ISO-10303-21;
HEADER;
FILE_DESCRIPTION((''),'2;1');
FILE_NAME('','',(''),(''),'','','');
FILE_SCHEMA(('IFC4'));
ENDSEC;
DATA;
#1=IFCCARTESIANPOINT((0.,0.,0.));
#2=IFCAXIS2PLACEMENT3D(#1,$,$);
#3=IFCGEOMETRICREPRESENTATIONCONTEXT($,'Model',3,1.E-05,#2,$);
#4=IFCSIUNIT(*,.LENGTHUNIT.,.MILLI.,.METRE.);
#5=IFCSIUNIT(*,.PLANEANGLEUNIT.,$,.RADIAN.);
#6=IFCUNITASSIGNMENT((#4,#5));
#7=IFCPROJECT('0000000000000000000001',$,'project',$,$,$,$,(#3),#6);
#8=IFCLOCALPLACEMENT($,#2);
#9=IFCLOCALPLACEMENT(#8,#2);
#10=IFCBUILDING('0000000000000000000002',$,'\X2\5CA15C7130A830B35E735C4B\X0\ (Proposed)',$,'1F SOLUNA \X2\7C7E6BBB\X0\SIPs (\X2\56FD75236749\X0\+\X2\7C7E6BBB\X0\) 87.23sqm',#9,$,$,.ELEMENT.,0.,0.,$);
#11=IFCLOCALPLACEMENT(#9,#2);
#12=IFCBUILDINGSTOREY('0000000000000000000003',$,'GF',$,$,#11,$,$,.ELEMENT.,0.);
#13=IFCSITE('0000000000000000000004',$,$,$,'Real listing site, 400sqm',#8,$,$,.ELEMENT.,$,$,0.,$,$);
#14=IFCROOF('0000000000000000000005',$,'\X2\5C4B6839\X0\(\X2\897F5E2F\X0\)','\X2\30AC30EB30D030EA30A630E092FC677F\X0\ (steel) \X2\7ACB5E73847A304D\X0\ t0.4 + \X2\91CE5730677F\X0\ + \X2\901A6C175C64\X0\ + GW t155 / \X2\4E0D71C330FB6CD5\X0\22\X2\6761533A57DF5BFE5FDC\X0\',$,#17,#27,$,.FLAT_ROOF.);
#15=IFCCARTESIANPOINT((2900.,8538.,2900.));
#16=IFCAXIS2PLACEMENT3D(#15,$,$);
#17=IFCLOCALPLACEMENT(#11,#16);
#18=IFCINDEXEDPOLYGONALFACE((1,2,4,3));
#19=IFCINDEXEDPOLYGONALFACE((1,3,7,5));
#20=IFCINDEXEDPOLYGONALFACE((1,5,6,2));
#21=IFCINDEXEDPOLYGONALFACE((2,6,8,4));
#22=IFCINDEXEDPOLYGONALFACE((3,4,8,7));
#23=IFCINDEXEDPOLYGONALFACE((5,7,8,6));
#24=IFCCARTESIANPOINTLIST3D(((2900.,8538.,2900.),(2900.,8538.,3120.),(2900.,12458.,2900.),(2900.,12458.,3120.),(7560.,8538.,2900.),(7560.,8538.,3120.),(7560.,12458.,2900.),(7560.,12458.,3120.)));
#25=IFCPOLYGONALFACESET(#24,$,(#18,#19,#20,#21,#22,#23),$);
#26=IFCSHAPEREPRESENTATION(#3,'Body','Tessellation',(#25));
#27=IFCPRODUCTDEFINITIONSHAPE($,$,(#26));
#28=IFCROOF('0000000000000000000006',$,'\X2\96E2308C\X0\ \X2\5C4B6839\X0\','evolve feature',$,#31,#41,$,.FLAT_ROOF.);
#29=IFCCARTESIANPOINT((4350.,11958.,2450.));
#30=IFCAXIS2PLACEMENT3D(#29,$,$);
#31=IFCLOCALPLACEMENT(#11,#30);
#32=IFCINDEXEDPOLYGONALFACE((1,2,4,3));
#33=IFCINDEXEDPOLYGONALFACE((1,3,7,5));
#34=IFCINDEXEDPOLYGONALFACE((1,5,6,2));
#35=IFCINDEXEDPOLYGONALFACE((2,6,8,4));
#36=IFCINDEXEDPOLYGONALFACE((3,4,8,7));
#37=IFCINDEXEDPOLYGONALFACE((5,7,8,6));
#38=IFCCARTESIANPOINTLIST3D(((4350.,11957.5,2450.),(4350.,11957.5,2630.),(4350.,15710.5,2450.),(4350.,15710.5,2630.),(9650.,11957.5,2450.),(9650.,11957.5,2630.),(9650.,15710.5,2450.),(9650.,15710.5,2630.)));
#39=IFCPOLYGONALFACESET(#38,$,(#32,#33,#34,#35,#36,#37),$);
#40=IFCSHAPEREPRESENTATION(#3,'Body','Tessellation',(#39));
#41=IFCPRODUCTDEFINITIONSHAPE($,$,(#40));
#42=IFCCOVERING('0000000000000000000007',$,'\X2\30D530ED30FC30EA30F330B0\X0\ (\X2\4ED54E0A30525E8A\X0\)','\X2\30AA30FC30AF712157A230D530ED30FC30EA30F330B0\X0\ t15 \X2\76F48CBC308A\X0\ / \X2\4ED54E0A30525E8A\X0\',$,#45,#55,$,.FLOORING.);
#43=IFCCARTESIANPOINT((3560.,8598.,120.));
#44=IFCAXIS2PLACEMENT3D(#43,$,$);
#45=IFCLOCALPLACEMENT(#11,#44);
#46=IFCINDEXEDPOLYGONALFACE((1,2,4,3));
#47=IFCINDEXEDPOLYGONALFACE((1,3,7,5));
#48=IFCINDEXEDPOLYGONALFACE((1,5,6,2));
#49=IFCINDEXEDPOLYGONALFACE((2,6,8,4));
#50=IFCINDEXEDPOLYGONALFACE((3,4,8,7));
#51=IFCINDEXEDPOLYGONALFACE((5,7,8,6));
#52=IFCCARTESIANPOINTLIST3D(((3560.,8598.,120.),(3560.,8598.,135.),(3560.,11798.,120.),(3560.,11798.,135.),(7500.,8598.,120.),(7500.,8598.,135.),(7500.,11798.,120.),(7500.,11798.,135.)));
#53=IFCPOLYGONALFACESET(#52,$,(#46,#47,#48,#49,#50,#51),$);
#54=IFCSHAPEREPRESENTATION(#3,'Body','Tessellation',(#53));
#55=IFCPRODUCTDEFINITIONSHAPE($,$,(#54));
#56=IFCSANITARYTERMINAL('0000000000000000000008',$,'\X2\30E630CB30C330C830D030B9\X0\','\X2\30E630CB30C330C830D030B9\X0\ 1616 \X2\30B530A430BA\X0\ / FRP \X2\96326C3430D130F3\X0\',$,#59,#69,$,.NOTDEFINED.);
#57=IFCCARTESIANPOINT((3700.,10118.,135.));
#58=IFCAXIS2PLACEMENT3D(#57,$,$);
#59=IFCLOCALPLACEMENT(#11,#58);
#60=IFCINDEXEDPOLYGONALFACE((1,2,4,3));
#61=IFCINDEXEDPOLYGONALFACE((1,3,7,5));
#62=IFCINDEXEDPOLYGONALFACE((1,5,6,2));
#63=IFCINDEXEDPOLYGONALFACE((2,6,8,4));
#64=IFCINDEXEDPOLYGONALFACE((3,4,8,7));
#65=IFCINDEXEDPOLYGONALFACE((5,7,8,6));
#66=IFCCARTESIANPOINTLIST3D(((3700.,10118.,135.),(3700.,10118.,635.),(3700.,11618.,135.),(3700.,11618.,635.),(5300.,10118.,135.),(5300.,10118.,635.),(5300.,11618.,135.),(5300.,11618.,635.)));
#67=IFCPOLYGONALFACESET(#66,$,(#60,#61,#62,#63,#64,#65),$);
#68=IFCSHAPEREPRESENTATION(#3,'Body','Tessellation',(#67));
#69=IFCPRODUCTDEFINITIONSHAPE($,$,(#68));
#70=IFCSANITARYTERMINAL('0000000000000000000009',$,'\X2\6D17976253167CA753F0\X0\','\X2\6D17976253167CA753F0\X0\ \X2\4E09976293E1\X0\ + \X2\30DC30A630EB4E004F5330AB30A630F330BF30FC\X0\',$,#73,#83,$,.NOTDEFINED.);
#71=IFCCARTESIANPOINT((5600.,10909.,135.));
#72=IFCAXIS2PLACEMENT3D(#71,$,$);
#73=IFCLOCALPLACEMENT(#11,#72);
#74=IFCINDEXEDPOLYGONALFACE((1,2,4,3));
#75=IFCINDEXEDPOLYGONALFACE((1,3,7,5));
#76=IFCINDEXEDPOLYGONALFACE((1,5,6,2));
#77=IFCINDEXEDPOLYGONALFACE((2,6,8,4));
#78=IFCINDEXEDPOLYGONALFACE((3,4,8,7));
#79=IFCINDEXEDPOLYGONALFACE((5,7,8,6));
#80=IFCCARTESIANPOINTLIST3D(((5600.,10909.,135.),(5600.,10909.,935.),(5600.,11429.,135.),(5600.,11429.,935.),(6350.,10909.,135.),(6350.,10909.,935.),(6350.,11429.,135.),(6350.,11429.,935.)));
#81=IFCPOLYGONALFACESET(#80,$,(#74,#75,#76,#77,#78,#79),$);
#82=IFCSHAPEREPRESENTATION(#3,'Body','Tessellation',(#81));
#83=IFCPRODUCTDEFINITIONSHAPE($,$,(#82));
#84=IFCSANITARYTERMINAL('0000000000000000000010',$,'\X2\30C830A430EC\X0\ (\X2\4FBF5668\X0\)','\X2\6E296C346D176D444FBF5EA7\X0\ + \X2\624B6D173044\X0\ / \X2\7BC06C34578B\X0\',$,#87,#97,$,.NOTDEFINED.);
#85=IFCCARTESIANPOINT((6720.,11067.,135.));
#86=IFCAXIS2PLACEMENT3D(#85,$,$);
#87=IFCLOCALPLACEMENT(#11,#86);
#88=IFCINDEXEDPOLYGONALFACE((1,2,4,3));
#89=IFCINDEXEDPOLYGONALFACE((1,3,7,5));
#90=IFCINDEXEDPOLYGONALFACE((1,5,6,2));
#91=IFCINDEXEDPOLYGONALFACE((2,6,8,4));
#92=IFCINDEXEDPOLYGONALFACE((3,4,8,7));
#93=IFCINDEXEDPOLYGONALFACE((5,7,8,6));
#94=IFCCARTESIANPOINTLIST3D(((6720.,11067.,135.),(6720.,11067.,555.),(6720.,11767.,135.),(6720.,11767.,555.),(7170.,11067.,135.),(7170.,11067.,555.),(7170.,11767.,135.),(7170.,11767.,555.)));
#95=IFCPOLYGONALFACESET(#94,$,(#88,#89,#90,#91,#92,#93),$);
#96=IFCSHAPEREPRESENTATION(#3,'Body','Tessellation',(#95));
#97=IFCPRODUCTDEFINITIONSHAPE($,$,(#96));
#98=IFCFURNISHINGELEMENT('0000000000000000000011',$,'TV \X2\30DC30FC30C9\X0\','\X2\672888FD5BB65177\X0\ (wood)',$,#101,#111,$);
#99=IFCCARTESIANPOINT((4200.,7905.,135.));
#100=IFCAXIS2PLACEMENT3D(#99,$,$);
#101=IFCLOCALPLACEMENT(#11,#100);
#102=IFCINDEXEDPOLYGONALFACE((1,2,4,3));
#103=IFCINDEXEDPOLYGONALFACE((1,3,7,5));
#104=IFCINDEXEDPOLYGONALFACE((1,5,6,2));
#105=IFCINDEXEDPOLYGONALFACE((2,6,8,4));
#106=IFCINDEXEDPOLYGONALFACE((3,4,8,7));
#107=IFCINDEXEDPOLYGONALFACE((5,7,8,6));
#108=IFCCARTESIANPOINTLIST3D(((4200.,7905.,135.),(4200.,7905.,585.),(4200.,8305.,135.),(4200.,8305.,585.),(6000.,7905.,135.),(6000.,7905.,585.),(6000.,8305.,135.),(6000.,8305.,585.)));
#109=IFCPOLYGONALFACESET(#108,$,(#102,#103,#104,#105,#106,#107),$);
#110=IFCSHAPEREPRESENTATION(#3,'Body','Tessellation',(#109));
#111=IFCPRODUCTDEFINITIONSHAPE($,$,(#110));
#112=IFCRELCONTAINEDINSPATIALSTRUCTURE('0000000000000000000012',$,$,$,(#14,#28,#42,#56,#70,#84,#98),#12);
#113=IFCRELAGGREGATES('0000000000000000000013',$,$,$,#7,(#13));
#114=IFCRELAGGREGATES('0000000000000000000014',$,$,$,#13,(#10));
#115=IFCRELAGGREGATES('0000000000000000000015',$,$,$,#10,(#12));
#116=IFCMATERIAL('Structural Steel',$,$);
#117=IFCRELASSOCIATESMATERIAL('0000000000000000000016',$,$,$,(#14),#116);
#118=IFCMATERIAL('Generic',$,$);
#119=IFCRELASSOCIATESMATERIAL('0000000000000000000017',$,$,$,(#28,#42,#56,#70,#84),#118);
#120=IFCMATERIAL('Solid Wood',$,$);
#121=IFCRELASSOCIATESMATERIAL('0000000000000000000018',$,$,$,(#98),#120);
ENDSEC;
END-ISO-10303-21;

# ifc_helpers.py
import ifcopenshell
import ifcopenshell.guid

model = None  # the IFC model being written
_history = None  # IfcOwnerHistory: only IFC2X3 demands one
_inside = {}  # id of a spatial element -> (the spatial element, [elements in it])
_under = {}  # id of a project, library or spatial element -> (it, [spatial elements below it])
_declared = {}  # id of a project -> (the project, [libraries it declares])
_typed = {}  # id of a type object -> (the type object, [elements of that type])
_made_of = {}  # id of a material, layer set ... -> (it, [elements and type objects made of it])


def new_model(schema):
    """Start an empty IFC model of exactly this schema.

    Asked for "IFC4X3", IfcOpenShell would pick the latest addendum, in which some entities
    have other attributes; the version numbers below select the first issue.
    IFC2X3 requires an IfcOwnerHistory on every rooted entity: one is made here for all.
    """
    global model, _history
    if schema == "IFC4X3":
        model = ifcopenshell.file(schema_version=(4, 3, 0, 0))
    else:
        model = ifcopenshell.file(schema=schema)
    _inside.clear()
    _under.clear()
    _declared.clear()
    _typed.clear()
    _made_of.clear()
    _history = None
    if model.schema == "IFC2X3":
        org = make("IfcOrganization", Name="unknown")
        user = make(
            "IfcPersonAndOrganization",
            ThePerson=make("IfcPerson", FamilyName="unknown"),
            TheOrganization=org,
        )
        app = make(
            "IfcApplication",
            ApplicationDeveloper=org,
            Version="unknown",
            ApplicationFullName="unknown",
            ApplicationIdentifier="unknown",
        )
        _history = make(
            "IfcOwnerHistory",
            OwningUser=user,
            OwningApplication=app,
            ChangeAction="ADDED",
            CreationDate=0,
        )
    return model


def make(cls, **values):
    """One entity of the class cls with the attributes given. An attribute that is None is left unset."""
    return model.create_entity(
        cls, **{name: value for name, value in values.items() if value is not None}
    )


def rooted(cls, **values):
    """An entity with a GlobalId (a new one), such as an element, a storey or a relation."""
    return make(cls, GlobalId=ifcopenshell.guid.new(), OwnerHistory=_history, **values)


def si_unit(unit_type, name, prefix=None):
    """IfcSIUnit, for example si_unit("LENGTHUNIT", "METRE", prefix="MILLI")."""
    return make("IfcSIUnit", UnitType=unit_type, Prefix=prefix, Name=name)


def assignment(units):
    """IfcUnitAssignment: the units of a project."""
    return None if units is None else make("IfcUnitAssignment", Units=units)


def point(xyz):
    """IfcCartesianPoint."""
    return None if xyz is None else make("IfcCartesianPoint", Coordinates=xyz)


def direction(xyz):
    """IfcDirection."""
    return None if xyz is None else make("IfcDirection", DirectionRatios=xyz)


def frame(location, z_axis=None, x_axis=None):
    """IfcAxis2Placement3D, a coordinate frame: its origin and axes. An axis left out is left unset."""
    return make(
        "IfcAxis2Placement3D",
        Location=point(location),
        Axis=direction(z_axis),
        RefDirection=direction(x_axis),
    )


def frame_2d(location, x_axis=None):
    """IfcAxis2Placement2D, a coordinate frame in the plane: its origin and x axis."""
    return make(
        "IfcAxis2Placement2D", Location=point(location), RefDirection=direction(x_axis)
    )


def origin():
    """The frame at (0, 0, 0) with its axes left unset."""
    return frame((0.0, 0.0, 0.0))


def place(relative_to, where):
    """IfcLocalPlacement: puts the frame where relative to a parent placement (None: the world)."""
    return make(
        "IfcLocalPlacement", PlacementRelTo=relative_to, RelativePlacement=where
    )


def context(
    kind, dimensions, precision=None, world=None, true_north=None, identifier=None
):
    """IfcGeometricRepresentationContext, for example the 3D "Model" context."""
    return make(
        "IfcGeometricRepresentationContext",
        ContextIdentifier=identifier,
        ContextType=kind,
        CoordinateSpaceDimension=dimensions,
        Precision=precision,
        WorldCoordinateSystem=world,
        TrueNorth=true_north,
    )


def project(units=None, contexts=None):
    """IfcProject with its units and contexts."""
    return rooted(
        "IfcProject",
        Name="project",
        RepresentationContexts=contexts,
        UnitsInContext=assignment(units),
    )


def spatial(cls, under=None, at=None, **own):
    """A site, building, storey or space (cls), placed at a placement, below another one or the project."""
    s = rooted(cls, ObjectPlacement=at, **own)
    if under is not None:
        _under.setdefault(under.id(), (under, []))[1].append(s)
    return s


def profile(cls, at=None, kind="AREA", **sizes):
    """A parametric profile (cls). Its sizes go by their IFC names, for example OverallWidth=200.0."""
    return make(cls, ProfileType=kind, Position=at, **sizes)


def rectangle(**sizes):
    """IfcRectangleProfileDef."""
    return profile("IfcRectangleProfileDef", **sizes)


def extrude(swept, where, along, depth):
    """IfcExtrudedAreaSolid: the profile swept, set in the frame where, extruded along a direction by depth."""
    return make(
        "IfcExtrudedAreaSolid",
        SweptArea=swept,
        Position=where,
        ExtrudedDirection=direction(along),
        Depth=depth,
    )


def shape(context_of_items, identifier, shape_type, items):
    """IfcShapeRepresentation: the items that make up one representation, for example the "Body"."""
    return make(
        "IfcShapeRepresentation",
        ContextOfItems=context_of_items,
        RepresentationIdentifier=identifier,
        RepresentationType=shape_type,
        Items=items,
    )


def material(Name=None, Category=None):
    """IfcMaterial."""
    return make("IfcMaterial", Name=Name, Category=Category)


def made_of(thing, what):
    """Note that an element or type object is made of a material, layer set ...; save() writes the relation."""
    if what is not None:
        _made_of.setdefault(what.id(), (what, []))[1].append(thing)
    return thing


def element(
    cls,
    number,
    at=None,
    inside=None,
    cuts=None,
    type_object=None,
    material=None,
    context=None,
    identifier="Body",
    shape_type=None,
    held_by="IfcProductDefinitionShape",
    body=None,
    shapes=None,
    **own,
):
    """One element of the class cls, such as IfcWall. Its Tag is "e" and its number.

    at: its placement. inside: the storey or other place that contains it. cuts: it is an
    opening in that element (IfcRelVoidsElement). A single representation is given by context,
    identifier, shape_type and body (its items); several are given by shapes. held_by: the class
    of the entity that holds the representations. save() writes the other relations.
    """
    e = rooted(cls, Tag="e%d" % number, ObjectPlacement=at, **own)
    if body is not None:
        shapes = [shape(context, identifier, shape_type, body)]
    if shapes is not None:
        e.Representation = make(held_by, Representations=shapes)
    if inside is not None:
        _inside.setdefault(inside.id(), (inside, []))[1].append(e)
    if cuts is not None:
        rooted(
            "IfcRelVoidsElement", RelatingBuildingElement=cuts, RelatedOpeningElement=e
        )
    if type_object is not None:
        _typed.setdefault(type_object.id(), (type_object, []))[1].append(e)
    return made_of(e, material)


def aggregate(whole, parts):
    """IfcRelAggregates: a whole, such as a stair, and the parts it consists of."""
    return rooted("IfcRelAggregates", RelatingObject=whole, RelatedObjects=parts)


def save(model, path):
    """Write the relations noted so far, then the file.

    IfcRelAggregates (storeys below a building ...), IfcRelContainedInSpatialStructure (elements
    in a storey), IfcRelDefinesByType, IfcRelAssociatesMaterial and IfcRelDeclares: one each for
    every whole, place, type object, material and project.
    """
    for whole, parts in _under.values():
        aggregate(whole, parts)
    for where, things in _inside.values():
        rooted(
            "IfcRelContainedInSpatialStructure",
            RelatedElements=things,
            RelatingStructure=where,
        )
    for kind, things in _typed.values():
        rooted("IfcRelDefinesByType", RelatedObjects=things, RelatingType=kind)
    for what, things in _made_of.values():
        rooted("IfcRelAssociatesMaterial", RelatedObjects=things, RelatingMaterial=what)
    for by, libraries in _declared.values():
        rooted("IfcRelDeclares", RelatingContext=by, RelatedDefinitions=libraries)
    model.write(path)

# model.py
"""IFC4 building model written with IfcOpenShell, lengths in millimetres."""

from ifc_helpers import new_model, si_unit, frame, frame_2d, origin, place, context, project, spatial, rectangle, extrude, material, element, save


model = new_model("IFC4")

# Units and contexts
model_context = context("Model", 3, precision=1e-05, world=origin())
ifc_project = project(units=[si_unit("LENGTHUNIT", "METRE", prefix="MILLI"), si_unit("PLANEANGLEUNIT", "RADIAN")], contexts=[model_context])

# Site, building, storey
site_placement = place(None, origin())
site = spatial("IfcSite", under=ifc_project, at=site_placement, ObjectType="Real listing site, 400sqm", CompositionType="ELEMENT", RefElevation=0.0)
building_placement = place(site_placement, origin())
building = spatial("IfcBuilding", under=site, at=building_placement, Name="岡山エコ平屋 (Proposed)", ObjectType="1F SOLUNA 籾殻SIPs (国産杉+籾殻) 87.23sqm", CompositionType="ELEMENT", ElevationOfRefHeight=0.0, ElevationOfTerrain=0.0)
storey_placement = place(building_placement, origin())
storey = spatial("IfcBuildingStorey", under=building, at=storey_placement, Name="GF", CompositionType="ELEMENT", Elevation=0.0)

# Shared definitions
ifc_material_1 = material(Name="Solid Wood")
ifc_material_2 = material(Name="Generic")

# Roofs
ifc_material_3 = material(Name="Structural Steel")
roof_1_placement = place(storey_placement, frame((2900.0, 8538.0, 2900.0)))
element("IfcRoof", 1, at=roof_1_placement, inside=storey, material=ifc_material_3, Name="屋根(西帯)", Description="ガルバリウム鋼板 (steel) 立平葺き t0.4 + 野地板 + 通気層 + GW t155 / 不燃・法22条区域対応", PredefinedType="FLAT_ROOF", context=model_context, shape_type="SweptSolid", body=[
    extrude(rectangle(XDim=4660.0, YDim=3920.0, at=frame_2d((2330.0, 1960.0))), frame((2900.0, 8538.0, 2900.0)), (0.0, 0.0, 1.0), 220.0),
])
roof_2_placement = place(storey_placement, frame((4350.0, 11958.0, 2450.0)))
element("IfcRoof", 2, at=roof_2_placement, inside=storey, material=ifc_material_2, Name="離れ 屋根", Description="evolve feature", PredefinedType="FLAT_ROOF", context=model_context, shape_type="SweptSolid", body=[
    extrude(rectangle(XDim=5300.0, YDim=3753.0, at=frame_2d((2650.0, 1876.0))), frame((4350.0, 11958.0, 2450.0)), (0.0, 0.0, 1.0), 180.0),
])

# Covering
covering_placement = place(storey_placement, frame((3560.0, 8598.0, 120.0)))
element("IfcCovering", 3, at=covering_placement, inside=storey, material=ifc_material_2, Name="フローリング (仕上げ床)", Description="オーク無垢フローリング t15 直貼り / 仕上げ床", PredefinedType="FLOORING", context=model_context, shape_type="SweptSolid", body=[
    extrude(rectangle(XDim=3940.0, YDim=3200.0, at=frame_2d((1970.0, 1600.0))), frame((3560.0, 8598.0, 120.0)), (0.0, 0.0, 1.0), 15.0),
])

# Sanitary terminals
sanitary_terminal_1_placement = place(storey_placement, frame((3700.0, 10118.0, 135.0)))
element("IfcSanitaryTerminal", 4, at=sanitary_terminal_1_placement, inside=storey, material=ifc_material_2, Name="ユニットバス", Description="ユニットバス 1616 サイズ / FRP 防水パン", PredefinedType="NOTDEFINED", context=model_context, shape_type="SweptSolid", body=[
    extrude(rectangle(XDim=1600.0, YDim=1500.0, at=frame_2d((800.0, 750.0))), frame((3700.0, 10118.0, 135.0)), (0.0, 0.0, 1.0), 500.0),
])
sanitary_terminal_2_placement = place(storey_placement, frame((5600.0, 10909.0, 135.0)))
element("IfcSanitaryTerminal", 5, at=sanitary_terminal_2_placement, inside=storey, material=ifc_material_2, Name="洗面化粧台", Description="洗面化粧台 三面鏡 + ボウル一体カウンター", PredefinedType="NOTDEFINED", context=model_context, shape_type="SweptSolid", body=[
    extrude(rectangle(XDim=750.0, YDim=520.0, at=frame_2d((375.0, 260.0))), frame((5600.0, 10909.0, 135.0)), (0.0, 0.0, 1.0), 800.0),
])
sanitary_terminal_3_placement = place(storey_placement, frame((6720.0, 11067.0, 135.0)))
element("IfcSanitaryTerminal", 6, at=sanitary_terminal_3_placement, inside=storey, material=ifc_material_2, Name="トイレ (便器)", Description="温水洗浄便座 + 手洗い / 節水型", PredefinedType="NOTDEFINED", context=model_context, shape_type="SweptSolid", body=[
    extrude(rectangle(XDim=450.0, YDim=700.0, at=frame_2d((225.0, 350.0))), frame((6720.0, 11067.0, 135.0)), (0.0, 0.0, 1.0), 420.0),
])

# Furnishing element
furnishing_placement = place(storey_placement, frame((4200.0, 7905.0, 135.0)))
element("IfcFurnishingElement", 7, at=furnishing_placement, inside=storey, material=ifc_material_1, Name="TV ボード", Description="木製家具 (wood)", context=model_context, shape_type="SweptSolid", body=[
    extrude(rectangle(XDim=1800.0, YDim=400.0, at=frame_2d((900.0, 200.0))), frame((4200.0, 7905.0, 135.0)), (0.0, 0.0, 1.0), 450.0),
])

save(model, "model.ifc")
